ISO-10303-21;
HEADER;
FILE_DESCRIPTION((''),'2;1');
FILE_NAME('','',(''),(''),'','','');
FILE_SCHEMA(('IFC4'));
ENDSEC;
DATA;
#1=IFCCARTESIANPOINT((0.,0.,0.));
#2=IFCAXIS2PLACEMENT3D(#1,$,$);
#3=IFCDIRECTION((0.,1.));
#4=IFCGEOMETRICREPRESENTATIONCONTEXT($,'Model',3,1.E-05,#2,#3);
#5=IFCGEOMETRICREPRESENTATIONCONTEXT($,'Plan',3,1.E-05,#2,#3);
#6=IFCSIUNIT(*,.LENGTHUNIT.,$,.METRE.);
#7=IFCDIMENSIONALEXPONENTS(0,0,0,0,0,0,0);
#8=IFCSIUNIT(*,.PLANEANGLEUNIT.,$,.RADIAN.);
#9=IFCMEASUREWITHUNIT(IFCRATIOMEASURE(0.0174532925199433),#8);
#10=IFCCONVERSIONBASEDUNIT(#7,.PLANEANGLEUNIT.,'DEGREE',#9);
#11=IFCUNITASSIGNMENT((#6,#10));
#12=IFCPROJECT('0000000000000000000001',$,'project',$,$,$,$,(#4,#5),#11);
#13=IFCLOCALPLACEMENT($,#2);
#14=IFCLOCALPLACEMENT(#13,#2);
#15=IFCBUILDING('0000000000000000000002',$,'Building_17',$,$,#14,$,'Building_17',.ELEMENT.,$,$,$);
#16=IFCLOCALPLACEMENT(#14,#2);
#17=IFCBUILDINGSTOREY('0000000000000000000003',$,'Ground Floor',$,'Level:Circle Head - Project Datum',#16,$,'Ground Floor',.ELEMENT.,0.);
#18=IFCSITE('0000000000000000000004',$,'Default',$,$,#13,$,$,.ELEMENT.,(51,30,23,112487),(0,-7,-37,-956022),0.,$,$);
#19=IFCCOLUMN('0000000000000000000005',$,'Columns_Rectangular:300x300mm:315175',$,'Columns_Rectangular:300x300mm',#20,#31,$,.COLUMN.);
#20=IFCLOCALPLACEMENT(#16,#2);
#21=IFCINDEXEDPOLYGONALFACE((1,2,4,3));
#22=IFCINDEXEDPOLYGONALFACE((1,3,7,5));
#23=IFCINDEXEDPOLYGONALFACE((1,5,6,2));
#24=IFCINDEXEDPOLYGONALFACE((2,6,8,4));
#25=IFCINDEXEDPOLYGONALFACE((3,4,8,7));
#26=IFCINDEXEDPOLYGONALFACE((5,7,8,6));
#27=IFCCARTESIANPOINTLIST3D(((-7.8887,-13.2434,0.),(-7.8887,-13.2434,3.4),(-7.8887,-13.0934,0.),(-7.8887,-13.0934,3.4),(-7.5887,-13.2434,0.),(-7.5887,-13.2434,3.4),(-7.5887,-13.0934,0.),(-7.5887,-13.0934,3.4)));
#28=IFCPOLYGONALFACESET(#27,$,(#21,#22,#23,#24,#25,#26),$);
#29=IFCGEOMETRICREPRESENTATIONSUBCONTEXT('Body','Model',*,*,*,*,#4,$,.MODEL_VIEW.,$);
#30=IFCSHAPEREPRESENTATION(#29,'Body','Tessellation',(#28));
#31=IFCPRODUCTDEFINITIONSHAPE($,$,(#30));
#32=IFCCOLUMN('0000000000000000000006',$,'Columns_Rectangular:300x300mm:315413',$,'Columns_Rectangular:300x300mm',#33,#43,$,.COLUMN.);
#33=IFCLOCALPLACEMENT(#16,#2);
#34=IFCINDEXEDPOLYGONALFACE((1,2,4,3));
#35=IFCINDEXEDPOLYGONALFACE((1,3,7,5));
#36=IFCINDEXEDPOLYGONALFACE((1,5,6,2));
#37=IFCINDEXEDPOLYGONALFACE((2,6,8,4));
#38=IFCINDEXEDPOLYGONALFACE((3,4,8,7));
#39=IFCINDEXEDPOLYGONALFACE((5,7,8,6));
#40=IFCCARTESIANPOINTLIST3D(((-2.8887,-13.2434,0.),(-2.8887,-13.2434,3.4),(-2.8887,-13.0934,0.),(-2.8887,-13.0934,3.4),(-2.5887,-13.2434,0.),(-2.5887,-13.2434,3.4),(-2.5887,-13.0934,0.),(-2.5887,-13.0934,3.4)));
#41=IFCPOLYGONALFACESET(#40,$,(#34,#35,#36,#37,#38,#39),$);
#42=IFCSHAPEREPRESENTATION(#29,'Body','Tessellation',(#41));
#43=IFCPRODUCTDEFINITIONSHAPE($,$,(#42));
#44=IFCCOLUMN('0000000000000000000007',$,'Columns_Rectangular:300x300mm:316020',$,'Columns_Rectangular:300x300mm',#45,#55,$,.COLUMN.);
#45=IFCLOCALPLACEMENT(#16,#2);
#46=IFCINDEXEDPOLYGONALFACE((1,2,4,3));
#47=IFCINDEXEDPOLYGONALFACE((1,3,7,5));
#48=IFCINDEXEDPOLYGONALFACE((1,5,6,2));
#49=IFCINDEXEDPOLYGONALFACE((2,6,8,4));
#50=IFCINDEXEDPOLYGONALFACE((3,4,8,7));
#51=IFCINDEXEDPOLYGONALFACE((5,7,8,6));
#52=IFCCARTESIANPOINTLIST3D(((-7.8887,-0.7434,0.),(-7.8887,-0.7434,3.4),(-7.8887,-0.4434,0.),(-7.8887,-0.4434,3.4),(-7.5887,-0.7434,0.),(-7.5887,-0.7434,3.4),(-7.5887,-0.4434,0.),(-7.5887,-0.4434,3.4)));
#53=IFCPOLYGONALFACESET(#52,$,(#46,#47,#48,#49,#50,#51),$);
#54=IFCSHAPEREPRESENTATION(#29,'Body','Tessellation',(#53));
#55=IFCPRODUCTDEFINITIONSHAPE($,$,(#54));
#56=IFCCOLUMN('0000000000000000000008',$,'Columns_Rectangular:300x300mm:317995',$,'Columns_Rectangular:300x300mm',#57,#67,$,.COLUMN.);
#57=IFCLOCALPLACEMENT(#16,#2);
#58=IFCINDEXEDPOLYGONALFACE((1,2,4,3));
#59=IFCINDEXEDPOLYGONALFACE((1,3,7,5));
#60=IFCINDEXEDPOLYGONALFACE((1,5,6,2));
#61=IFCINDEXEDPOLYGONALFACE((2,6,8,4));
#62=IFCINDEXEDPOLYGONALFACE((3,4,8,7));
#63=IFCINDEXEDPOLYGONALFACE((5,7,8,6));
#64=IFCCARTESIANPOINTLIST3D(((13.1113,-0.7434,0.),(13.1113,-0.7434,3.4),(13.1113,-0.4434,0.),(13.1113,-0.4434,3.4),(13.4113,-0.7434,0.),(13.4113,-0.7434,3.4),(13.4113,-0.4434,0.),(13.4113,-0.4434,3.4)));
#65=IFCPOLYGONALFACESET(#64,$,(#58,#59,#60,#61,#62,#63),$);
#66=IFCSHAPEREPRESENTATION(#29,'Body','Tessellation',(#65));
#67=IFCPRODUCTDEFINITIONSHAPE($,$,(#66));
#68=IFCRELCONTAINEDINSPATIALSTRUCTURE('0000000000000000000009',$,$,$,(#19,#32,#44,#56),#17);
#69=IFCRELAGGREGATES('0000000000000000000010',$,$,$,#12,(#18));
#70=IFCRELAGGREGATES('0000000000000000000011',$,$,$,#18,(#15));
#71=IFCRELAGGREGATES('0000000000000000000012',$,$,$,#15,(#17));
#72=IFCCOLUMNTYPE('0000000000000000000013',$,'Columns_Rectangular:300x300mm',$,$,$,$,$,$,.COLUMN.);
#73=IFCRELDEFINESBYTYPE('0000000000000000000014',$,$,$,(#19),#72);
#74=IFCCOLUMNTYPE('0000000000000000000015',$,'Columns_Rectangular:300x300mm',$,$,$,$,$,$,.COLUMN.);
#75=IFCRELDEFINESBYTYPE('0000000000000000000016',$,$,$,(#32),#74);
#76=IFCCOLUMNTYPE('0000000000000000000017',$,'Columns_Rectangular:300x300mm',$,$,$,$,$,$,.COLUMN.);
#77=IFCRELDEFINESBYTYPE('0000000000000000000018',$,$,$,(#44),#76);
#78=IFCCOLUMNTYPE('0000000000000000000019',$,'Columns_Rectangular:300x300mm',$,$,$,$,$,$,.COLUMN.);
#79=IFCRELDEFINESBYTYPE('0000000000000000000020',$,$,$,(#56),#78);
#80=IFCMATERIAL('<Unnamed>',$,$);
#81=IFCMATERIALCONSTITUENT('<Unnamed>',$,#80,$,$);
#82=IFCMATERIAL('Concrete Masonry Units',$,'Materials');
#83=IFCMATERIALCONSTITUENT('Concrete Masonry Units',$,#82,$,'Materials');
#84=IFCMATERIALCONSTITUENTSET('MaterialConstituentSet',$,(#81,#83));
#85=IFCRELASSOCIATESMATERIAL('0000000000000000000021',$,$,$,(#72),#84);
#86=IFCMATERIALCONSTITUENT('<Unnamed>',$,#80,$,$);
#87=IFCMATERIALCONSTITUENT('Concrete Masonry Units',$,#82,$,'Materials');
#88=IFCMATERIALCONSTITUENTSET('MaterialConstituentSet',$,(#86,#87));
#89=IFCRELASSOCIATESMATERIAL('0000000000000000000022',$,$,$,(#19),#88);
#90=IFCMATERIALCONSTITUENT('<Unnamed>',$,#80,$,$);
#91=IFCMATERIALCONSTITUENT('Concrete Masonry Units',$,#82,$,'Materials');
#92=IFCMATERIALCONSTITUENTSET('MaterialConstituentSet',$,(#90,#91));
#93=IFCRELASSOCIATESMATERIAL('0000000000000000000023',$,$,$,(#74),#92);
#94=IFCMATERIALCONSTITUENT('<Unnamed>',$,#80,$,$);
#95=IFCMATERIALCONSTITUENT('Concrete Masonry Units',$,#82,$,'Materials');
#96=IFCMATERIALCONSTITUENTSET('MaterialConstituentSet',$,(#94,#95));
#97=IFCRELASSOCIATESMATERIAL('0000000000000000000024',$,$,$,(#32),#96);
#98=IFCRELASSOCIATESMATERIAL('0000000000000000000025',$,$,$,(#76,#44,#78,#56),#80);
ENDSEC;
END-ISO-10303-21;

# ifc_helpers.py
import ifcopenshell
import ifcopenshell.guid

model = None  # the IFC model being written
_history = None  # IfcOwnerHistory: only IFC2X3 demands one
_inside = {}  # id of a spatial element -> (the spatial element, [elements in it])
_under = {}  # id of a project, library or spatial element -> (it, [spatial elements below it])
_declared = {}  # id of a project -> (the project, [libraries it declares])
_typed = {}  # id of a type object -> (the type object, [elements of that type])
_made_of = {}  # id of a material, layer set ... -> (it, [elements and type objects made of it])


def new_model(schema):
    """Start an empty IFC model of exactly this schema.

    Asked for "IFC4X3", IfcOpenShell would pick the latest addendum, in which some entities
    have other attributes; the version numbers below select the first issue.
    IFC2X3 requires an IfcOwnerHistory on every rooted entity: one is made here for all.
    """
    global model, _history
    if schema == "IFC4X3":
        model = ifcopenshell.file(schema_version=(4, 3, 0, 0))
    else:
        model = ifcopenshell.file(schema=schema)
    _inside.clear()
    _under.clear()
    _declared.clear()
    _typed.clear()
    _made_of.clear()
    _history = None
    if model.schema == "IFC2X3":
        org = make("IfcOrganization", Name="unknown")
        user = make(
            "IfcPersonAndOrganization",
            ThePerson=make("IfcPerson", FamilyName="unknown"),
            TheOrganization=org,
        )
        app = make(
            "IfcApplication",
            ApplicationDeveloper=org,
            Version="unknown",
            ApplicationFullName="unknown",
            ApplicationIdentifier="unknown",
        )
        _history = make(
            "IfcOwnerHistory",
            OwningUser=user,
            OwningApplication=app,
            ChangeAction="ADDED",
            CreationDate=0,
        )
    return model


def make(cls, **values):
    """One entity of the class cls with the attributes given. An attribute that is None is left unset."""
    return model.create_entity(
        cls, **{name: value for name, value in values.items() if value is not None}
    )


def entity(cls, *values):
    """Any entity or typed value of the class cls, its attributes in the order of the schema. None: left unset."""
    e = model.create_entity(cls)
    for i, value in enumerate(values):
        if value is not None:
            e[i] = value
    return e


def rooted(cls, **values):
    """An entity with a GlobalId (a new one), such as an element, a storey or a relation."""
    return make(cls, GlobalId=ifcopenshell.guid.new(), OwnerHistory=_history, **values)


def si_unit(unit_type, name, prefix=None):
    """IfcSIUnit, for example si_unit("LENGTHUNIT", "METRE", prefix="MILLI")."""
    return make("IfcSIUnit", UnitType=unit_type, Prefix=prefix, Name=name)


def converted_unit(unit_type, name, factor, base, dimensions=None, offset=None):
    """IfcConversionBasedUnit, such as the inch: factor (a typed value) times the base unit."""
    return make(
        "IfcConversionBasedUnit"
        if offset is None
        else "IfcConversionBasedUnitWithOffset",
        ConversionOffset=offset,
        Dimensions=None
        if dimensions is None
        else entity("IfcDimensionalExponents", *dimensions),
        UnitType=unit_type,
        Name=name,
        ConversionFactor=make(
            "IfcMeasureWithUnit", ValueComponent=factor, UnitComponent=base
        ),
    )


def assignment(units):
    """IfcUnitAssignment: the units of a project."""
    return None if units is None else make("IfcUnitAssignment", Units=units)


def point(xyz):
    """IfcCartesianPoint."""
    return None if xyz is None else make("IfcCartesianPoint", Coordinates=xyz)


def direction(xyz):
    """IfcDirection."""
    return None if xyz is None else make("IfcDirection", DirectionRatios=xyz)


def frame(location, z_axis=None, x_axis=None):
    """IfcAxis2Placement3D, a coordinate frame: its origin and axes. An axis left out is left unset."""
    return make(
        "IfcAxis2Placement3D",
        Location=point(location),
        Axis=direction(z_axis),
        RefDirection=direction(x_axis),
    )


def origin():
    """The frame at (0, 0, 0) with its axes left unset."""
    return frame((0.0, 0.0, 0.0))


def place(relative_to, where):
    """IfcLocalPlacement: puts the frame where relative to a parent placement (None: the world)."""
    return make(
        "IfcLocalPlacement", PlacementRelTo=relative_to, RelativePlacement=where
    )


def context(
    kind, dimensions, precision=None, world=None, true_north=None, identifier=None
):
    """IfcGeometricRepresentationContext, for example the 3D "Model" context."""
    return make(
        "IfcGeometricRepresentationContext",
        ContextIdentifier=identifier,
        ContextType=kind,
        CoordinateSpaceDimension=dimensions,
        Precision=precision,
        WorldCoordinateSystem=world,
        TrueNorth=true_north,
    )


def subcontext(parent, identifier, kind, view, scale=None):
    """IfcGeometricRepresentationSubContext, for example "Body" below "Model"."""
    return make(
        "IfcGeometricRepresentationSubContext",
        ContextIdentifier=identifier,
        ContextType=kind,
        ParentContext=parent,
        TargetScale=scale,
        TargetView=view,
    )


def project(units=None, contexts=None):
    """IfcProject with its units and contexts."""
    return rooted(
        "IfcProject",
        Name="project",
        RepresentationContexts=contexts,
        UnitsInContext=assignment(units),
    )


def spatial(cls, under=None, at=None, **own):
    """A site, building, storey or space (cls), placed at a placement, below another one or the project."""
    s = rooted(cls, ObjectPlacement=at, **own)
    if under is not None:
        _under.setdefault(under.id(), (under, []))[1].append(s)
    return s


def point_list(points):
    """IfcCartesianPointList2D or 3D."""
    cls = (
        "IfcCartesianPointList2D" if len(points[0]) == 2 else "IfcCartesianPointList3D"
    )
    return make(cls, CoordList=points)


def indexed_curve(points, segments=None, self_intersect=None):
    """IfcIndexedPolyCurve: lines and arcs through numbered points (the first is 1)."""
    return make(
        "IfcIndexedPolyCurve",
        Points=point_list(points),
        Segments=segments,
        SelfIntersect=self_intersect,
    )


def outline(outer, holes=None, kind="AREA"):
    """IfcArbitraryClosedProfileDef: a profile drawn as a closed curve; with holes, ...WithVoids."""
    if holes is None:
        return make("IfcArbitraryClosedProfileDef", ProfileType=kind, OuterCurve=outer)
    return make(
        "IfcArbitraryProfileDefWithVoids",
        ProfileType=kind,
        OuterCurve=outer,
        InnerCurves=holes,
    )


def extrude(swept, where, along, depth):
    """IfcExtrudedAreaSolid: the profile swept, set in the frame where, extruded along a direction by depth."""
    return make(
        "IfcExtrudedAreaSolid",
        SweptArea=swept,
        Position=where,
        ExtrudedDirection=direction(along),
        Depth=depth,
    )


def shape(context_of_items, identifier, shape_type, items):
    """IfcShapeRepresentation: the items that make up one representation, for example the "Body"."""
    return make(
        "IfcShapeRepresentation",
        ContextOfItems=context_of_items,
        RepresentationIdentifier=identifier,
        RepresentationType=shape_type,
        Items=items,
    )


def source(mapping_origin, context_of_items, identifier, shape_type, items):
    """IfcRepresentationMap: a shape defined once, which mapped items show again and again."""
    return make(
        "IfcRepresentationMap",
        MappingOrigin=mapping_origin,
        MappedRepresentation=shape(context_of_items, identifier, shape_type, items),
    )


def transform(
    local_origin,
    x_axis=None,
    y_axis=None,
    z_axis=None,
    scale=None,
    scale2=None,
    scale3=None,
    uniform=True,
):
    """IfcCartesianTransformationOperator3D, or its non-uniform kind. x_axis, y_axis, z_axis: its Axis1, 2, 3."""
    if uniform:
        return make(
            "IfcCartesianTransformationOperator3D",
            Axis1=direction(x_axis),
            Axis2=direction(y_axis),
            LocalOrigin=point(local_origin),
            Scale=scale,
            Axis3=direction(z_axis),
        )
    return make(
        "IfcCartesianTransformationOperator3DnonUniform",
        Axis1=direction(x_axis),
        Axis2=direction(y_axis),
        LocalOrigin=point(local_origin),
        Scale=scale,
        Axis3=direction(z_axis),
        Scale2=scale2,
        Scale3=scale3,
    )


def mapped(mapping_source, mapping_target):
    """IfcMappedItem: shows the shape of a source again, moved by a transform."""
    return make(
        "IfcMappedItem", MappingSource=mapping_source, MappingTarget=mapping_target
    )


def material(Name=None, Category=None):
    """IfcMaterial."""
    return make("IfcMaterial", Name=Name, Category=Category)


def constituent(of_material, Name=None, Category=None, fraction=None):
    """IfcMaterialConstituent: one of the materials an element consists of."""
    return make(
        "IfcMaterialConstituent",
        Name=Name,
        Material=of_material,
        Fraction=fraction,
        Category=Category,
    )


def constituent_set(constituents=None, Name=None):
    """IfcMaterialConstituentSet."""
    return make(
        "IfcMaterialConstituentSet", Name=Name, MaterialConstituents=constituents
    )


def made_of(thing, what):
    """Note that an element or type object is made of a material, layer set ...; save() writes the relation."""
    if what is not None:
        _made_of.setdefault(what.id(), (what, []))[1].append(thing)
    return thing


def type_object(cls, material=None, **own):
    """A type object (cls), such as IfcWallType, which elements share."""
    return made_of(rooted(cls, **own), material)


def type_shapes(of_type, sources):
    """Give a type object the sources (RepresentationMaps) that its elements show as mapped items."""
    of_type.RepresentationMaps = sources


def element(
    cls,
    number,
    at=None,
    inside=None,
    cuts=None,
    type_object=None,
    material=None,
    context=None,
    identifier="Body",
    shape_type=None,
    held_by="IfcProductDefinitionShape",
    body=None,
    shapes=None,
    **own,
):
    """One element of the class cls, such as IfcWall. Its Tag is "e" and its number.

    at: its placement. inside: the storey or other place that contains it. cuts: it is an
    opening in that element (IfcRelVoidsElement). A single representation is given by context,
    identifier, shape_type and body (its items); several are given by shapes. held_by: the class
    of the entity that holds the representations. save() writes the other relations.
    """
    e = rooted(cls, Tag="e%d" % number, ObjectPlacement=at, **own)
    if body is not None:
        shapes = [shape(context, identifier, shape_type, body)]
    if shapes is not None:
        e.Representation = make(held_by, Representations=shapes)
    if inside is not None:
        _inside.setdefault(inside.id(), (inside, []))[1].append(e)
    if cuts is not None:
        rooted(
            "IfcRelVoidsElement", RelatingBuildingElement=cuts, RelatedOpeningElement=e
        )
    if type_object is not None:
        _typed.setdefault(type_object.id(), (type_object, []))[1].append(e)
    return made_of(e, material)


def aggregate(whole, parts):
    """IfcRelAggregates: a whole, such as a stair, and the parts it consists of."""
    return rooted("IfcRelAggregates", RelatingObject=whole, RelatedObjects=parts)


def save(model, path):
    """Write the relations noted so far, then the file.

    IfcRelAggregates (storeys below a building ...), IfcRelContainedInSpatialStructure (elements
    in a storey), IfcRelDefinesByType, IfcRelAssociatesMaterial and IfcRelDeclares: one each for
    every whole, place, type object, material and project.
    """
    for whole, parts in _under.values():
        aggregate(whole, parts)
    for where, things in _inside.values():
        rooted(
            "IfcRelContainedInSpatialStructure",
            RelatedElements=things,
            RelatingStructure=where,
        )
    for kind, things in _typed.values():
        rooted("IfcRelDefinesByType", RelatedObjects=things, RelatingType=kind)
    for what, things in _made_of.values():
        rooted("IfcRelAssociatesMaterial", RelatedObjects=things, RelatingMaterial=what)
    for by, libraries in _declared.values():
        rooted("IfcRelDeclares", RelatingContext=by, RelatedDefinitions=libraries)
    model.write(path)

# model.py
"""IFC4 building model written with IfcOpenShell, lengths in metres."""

from ifc_helpers import new_model, entity, si_unit, converted_unit, direction, frame, origin, place, context, subcontext, project, spatial, indexed_curve, outline, extrude, source, transform, mapped, material, constituent, constituent_set, type_object, type_shapes, element, save


model = new_model("IFC4")

# Units and contexts
model_context = context("Model", 3, precision=1e-05, world=origin(), true_north=direction((0.0, 1.0)))
plan_context = context("Plan", 3, precision=1e-05, world=origin(), true_north=direction((0.0, 1.0)))
body_context = subcontext(model_context, "Body", "Model", "MODEL_VIEW")
ifc_project = project(units=[si_unit("LENGTHUNIT", "METRE"), converted_unit("PLANEANGLEUNIT", "DEGREE", entity("IfcRatioMeasure", 0.0174532925199433), si_unit("PLANEANGLEUNIT", "RADIAN"), dimensions=[0, 0, 0, 0, 0, 0, 0])], contexts=[model_context, plan_context])

# Site, building, storey
site_placement = place(None, origin())
site = spatial("IfcSite", under=ifc_project, at=site_placement, Name="Default", CompositionType="ELEMENT", RefLatitude=(51, 30, 23, 112487), RefLongitude=(0, -7, -37, -956022), RefElevation=0.0)
building_placement = place(site_placement, origin())
building = spatial("IfcBuilding", under=site, at=building_placement, Name="Building_17", LongName="Building_17", CompositionType="ELEMENT")
storey_placement = place(building_placement, origin())
storey = spatial("IfcBuildingStorey", under=building, at=storey_placement, Name="Ground Floor", ObjectType="Level:Circle Head - Project Datum", LongName="Ground Floor", CompositionType="ELEMENT", Elevation=0.0)

# Columns
ifc_material_1 = material(Name="<Unnamed>")
ifc_constituent_1 = constituent(ifc_material_1, Name="<Unnamed>")
ifc_material_2 = material(Name="Concrete Masonry Units", Category="Materials")
ifc_constituent_2 = constituent(ifc_material_2, Name="Concrete Masonry Units", Category="Materials")
ifc_constituent_set_1 = constituent_set(constituents=[ifc_constituent_1, ifc_constituent_2], Name="MaterialConstituentSet")
ifc_constituent_3 = constituent(ifc_material_1, Name="<Unnamed>")
ifc_constituent_4 = constituent(ifc_material_2, Name="Concrete Masonry Units", Category="Materials")
ifc_constituent_set_2 = constituent_set(constituents=[ifc_constituent_3, ifc_constituent_4], Name="MaterialConstituentSet")
column_type_1 = type_object("IfcColumnType", Name="Columns_Rectangular:300x300mm", PredefinedType="COLUMN", material=ifc_constituent_set_2)
shared_shape_1 = source(origin(), body_context, "Body", "SweptSolid", [
    extrude(outline(indexed_curve([(-0.075, -0.15), (0.075, -0.15), (0.075, 0.15), (-0.075, 0.15), (-0.075, -0.15)], self_intersect=False)), frame((-7.7387, -13.1684, 0.0), z_axis=(0.0, 0.0, 1.0), x_axis=(0.0, -1.0, 0.0)), (0.0, 0.0, 1.0), 3.4),
])
type_shapes(column_type_1, [shared_shape_1])
column_1_placement = place(storey_placement, origin())
element("IfcColumn", 1, at=column_1_placement, inside=storey, type_object=column_type_1, material=ifc_constituent_set_1, Name="Columns_Rectangular:300x300mm:315175", ObjectType="Columns_Rectangular:300x300mm", PredefinedType="COLUMN", context=body_context, shape_type="MappedRepresentation", body=[
    mapped(shared_shape_1, transform((0.0, 0.0, 0.0), scale=1.0)),
])
ifc_constituent_5 = constituent(ifc_material_1, Name="<Unnamed>")
ifc_constituent_6 = constituent(ifc_material_2, Name="Concrete Masonry Units", Category="Materials")
ifc_constituent_set_3 = constituent_set(constituents=[ifc_constituent_5, ifc_constituent_6], Name="MaterialConstituentSet")
ifc_constituent_7 = constituent(ifc_material_1, Name="<Unnamed>")
ifc_constituent_8 = constituent(ifc_material_2, Name="Concrete Masonry Units", Category="Materials")
ifc_constituent_set_4 = constituent_set(constituents=[ifc_constituent_7, ifc_constituent_8], Name="MaterialConstituentSet")
column_type_2 = type_object("IfcColumnType", Name="Columns_Rectangular:300x300mm", PredefinedType="COLUMN", material=ifc_constituent_set_4)
shared_shape_2 = source(origin(), body_context, "Body", "SweptSolid", [
    extrude(outline(indexed_curve([(-0.075, -0.15), (0.075, -0.15), (0.075, 0.15), (-0.075, 0.15), (-0.075, -0.15)], self_intersect=False)), frame((-2.7387, -13.1684, 0.0), z_axis=(0.0, 0.0, 1.0), x_axis=(0.0, -1.0, 0.0)), (0.0, 0.0, 1.0), 3.4),
])
type_shapes(column_type_2, [shared_shape_2])
column_2_placement = place(storey_placement, origin())
element("IfcColumn", 2, at=column_2_placement, inside=storey, type_object=column_type_2, material=ifc_constituent_set_3, Name="Columns_Rectangular:300x300mm:315413", ObjectType="Columns_Rectangular:300x300mm", PredefinedType="COLUMN", context=body_context, shape_type="MappedRepresentation", body=[
    mapped(shared_shape_2, transform((0.0, 0.0, 0.0), scale=1.0)),
])
column_type_3 = type_object("IfcColumnType", Name="Columns_Rectangular:300x300mm", PredefinedType="COLUMN", material=ifc_material_1)
shared_shape_3 = source(origin(), body_context, "Body", "SweptSolid", [
    extrude(outline(indexed_curve([(-0.15, -0.15), (0.15, -0.15), (0.15, 0.15), (-0.15, 0.15), (-0.15, -0.15)], self_intersect=False)), frame((-7.7387, -0.5934, 0.0), z_axis=(0.0, 0.0, 1.0), x_axis=(0.0, -1.0, 0.0)), (0.0, 0.0, 1.0), 3.4),
])
type_shapes(column_type_3, [shared_shape_3])
column_3_placement = place(storey_placement, origin())
element("IfcColumn", 3, at=column_3_placement, inside=storey, type_object=column_type_3, material=ifc_material_1, Name="Columns_Rectangular:300x300mm:316020", ObjectType="Columns_Rectangular:300x300mm", PredefinedType="COLUMN", context=body_context, shape_type="MappedRepresentation", body=[
    mapped(shared_shape_3, transform((0.0, 0.0, 0.0), scale=1.0)),
])
column_type_4 = type_object("IfcColumnType", Name="Columns_Rectangular:300x300mm", PredefinedType="COLUMN", material=ifc_material_1)
shared_shape_4 = source(origin(), body_context, "Body", "SweptSolid", [
    extrude(outline(indexed_curve([(-0.15, -0.15), (0.15, -0.15), (0.15, 0.15), (-0.15, 0.15), (-0.15, -0.15)], self_intersect=False)), frame((13.2613, -0.5934, 0.0), z_axis=(0.0, 0.0, 1.0), x_axis=(0.0, -1.0, 0.0)), (0.0, 0.0, 1.0), 3.4),
])
type_shapes(column_type_4, [shared_shape_4])
column_4_placement = place(storey_placement, origin())
element("IfcColumn", 4, at=column_4_placement, inside=storey, type_object=column_type_4, material=ifc_material_1, Name="Columns_Rectangular:300x300mm:317995", ObjectType="Columns_Rectangular:300x300mm", PredefinedType="COLUMN", context=body_context, shape_type="MappedRepresentation", body=[
    mapped(shared_shape_4, transform((0.0, 0.0, 0.0), scale=1.0)),
])

save(model, "model.ifc")
